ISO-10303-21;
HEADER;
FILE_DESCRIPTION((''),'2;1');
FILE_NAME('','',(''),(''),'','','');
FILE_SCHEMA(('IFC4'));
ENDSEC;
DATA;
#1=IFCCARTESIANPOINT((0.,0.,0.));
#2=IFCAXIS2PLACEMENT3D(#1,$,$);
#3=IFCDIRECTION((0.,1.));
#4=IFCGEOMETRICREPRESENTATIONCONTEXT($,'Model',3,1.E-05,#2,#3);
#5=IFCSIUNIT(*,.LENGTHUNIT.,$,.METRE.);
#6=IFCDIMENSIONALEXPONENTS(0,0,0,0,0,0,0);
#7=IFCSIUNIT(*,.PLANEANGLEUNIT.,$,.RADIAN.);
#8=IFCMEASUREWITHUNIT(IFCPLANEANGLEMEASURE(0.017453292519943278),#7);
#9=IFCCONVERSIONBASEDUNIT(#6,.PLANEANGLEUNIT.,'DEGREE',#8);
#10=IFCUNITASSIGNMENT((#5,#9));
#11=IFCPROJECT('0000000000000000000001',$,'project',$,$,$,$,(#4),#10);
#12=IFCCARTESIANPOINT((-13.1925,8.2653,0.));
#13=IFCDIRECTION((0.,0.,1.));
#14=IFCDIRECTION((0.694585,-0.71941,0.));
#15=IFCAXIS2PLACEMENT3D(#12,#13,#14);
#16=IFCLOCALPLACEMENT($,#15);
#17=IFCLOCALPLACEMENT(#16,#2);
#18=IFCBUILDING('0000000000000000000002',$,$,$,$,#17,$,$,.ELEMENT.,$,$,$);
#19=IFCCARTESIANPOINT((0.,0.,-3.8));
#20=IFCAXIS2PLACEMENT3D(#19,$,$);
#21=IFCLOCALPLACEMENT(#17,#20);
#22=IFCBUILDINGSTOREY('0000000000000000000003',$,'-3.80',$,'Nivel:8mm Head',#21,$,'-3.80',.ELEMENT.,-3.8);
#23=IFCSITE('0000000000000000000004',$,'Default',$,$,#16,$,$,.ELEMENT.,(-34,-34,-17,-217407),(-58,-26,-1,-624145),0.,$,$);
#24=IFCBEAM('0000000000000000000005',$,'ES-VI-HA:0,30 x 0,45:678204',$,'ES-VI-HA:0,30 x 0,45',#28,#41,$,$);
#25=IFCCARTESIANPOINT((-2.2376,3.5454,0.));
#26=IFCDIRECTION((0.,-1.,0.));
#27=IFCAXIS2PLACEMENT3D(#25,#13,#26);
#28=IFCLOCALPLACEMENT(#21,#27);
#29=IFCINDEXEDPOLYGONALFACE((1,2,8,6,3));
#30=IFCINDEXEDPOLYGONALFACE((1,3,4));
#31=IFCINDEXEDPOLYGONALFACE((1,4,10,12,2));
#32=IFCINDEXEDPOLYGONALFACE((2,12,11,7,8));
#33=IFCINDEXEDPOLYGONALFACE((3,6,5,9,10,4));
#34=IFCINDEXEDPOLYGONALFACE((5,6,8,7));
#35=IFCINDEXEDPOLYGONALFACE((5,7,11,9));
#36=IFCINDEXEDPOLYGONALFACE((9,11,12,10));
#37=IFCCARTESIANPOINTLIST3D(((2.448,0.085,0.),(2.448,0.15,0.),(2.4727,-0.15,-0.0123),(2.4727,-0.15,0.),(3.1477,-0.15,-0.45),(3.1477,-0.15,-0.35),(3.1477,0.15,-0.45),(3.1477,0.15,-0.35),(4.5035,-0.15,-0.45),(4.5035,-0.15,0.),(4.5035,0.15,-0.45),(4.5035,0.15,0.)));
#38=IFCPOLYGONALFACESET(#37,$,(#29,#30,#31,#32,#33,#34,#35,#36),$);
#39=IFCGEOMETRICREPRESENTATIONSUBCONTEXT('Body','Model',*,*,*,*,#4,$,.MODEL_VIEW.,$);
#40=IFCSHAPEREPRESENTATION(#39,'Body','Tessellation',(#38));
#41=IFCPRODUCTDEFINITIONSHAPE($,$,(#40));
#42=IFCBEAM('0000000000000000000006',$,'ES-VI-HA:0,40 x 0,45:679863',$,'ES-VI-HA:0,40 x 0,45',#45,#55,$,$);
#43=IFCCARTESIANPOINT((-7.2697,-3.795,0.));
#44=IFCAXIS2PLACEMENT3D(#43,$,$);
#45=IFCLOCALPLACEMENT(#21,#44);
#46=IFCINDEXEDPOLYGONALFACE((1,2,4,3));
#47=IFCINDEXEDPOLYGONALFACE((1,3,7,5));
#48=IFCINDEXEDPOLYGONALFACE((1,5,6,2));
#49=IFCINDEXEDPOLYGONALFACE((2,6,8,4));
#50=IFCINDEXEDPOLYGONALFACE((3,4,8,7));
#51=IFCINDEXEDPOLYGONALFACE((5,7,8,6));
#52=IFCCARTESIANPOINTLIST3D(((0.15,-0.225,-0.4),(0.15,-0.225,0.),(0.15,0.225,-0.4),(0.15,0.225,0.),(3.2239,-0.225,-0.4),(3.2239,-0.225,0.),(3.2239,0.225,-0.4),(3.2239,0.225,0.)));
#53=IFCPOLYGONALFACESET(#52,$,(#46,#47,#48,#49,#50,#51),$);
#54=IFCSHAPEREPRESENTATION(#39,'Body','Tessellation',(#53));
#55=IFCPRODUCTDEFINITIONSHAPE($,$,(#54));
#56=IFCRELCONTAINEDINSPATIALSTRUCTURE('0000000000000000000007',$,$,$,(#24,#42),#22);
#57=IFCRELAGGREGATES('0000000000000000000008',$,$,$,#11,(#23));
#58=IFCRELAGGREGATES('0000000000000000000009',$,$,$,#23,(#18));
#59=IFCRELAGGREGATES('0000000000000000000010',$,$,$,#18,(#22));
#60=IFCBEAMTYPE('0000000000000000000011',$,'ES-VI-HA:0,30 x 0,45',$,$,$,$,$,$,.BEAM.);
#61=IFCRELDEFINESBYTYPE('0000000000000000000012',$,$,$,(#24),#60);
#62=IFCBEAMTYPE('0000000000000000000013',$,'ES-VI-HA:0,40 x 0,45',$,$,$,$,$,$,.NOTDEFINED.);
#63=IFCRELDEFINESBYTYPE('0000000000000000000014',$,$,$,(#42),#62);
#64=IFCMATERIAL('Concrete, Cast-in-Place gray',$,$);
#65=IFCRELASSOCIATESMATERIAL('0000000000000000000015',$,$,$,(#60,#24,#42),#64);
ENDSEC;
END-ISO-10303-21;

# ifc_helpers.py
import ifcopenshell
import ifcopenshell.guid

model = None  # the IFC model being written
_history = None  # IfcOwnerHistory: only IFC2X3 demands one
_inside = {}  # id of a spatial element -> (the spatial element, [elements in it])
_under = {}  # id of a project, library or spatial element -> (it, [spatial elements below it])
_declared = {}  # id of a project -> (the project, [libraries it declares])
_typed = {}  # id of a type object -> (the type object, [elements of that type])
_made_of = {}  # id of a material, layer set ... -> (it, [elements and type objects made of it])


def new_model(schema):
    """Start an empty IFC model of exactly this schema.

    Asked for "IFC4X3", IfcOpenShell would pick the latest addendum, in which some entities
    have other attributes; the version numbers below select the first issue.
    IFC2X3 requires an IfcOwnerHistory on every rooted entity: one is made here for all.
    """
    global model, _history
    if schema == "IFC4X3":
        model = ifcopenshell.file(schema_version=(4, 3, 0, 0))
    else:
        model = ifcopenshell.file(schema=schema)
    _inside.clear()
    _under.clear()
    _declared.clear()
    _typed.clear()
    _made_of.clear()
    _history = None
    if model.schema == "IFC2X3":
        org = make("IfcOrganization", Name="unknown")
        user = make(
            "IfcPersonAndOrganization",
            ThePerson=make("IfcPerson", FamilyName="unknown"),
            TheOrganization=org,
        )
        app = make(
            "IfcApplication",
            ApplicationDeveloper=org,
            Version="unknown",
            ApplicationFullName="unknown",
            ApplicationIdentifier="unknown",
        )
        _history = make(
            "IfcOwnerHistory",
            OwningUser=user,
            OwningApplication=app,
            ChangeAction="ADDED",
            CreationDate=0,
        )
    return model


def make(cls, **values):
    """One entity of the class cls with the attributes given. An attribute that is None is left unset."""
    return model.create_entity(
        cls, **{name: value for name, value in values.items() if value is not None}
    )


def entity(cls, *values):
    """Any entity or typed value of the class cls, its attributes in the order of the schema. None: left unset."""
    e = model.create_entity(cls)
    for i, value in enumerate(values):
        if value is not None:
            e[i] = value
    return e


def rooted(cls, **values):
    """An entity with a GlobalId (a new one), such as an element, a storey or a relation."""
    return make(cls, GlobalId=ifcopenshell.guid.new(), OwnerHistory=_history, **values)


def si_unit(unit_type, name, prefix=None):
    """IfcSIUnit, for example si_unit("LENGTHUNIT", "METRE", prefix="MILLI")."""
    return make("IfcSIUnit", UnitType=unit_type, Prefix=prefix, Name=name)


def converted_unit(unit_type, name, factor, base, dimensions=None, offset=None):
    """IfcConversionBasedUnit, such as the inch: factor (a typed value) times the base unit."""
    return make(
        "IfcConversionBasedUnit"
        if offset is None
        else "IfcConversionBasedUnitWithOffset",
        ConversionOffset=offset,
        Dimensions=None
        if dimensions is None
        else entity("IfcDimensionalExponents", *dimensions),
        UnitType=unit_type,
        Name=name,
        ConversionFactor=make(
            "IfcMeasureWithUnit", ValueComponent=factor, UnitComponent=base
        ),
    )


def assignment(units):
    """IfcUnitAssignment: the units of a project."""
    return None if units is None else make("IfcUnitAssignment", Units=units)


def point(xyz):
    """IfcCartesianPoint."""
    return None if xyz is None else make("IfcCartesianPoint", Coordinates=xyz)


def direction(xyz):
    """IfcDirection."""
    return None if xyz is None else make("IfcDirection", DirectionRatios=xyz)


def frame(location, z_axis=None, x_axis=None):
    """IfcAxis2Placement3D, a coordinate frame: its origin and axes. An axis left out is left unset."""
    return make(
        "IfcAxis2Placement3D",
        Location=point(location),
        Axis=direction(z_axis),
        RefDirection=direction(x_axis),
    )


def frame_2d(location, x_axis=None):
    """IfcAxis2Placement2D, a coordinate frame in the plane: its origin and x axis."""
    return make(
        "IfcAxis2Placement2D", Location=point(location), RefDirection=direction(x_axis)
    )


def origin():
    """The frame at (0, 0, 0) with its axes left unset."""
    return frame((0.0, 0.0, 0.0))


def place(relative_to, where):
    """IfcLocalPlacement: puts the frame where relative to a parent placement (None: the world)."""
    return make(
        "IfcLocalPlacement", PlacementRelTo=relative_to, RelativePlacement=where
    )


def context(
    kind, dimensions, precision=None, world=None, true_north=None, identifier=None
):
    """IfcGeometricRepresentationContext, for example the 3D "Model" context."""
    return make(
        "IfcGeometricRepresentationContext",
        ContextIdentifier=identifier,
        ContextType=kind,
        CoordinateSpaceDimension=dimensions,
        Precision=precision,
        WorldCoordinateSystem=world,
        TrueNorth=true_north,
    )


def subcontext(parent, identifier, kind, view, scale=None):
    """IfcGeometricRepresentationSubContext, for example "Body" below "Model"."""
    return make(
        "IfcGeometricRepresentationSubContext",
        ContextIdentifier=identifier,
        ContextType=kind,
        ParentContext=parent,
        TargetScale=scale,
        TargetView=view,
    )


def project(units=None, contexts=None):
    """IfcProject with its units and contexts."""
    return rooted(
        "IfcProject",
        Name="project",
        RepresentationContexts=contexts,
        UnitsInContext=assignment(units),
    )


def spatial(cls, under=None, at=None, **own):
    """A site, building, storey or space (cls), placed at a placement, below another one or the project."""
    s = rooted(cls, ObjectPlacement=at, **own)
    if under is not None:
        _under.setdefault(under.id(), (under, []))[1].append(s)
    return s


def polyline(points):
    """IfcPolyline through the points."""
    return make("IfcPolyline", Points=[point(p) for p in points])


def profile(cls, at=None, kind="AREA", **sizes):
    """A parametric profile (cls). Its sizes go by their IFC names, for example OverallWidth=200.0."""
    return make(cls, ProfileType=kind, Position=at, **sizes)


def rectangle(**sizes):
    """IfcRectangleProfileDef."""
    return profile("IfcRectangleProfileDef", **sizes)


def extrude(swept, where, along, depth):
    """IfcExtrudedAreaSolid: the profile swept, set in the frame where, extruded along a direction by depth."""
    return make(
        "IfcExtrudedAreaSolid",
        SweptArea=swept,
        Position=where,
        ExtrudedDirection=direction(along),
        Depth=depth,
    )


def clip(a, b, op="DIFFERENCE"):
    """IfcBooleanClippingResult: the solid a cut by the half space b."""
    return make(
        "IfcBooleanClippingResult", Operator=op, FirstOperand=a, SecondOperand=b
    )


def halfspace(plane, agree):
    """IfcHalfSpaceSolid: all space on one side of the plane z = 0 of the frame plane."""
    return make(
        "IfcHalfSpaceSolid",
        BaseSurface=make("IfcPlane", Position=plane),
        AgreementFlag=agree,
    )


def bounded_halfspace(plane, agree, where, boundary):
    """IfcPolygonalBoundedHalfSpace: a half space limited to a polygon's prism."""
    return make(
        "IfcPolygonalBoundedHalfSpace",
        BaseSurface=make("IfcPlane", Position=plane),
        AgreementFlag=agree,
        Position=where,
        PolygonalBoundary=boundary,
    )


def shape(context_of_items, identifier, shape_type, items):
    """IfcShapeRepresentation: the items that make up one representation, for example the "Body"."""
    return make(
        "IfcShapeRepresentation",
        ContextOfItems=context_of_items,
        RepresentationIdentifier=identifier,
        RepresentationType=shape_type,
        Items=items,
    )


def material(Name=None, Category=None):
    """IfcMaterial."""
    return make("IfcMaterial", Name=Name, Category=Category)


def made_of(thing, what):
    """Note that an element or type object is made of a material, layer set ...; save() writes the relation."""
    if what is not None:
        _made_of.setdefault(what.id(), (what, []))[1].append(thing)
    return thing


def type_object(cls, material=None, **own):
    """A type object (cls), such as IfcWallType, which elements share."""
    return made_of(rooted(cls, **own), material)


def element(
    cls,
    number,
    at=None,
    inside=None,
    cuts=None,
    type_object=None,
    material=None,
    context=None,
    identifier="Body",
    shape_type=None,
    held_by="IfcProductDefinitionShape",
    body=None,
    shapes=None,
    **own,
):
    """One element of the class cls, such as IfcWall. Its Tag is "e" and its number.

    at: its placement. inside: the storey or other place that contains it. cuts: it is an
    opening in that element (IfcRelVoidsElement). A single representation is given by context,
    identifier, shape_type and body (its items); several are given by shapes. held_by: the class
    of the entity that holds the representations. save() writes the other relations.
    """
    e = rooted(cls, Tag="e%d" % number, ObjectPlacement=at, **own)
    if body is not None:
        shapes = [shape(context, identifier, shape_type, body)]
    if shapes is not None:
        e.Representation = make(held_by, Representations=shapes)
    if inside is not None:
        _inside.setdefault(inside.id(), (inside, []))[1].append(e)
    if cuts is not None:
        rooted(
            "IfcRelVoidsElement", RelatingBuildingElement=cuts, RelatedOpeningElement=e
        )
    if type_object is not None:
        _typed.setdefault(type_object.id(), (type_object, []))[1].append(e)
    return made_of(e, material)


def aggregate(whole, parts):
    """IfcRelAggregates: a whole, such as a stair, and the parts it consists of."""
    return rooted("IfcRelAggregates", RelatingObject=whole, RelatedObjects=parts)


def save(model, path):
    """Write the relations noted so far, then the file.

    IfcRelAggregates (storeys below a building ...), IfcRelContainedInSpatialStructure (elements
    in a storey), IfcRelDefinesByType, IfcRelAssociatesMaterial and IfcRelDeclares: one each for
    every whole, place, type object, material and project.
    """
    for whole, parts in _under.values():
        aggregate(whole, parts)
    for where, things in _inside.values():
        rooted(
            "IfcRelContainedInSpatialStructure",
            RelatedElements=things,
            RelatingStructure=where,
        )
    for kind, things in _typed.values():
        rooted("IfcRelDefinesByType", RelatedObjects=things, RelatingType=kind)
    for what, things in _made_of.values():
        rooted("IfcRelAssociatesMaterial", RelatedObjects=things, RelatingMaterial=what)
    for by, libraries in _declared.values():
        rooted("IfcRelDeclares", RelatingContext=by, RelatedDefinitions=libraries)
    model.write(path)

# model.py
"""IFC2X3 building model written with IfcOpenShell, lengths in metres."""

from ifc_helpers import new_model, entity, si_unit, converted_unit, direction, frame, frame_2d, origin, place, context, subcontext, project, spatial, polyline, rectangle, extrude, clip, halfspace, bounded_halfspace, material, type_object, element, save


model = new_model("IFC2X3")

# Units and contexts
model_context = context("Model", 3, precision=1e-05, world=origin(), true_north=direction((0.0, 1.0)))
body_context = subcontext(model_context, "Body", "Model", "MODEL_VIEW")
ifc_project = project(units=[si_unit("LENGTHUNIT", "METRE"), converted_unit("PLANEANGLEUNIT", "DEGREE", entity("IfcPlaneAngleMeasure", 0.017453292519943278), si_unit("PLANEANGLEUNIT", "RADIAN"), dimensions=[0, 0, 0, 0, 0, 0, 0])], contexts=[model_context])

# Site, building, storey
site_placement = place(None, frame((-13.1925, 8.2653, 0.0), z_axis=(0.0, 0.0, 1.0), x_axis=(0.694585, -0.71941, 0.0)))
site = spatial("IfcSite", under=ifc_project, at=site_placement, Name="Default", CompositionType="ELEMENT", RefLatitude=(-34, -34, -17, -217407), RefLongitude=(-58, -26, -1, -624145), RefElevation=0.0)
building_placement = place(site_placement, origin())
building = spatial("IfcBuilding", under=site, at=building_placement, CompositionType="ELEMENT")
storey_placement = place(building_placement, frame((0.0, 0.0, -3.8)))
storey = spatial("IfcBuildingStorey", under=building, at=storey_placement, Name="-3.80", ObjectType="Nivel:8mm Head", LongName="-3.80", CompositionType="ELEMENT", Elevation=-3.8)

# Beams
ifc_material_1 = material(Name="Concrete, Cast-in-Place gray")
beam_type_1 = type_object("IfcBeamType", Name="ES-VI-HA:0,30 x 0,45", PredefinedType="BEAM", material=ifc_material_1)
beam_1_placement = place(storey_placement, frame((-2.2376, 3.5454, 0.0), z_axis=(0.0, 0.0, 1.0), x_axis=(0.0, -1.0, 0.0)))
element("IfcBeam", 1, at=beam_1_placement, inside=storey, type_object=beam_type_1, material=ifc_material_1, Name="ES-VI-HA:0,30 x 0,45:678204", ObjectType="ES-VI-HA:0,30 x 0,45", context=body_context, shape_type="SweptSolid", body=[
    clip(clip(clip(extrude(rectangle(XDim=0.45, YDim=0.3, at=frame_2d((0.0, 0.0), x_axis=(0.0, 1.0))), frame((2.448, 0.0, -0.225), z_axis=(1.0, 0.0, 0.0), x_axis=(0.0, 1.0, 0.0)), (0.0, 0.0, 1.0), 2.0555), halfspace(frame((2.4569, 0.0, -0.4), z_axis=(-0.994528, -0.104473, 0.0), x_axis=(0.0, 0.0, 1.0)), False)), bounded_halfspace(frame((3.1477, -0.0015, -0.35), z_axis=(-0.447361, 0.0, -0.894354), x_axis=(0.0, 1.0, 0.0)), False, frame((2.448, 0.0, -0.225), z_axis=(1.0, 0.0, 0.0), x_axis=(0.0, 1.0, 0.0)), polyline([(0.15, -0.125), (-0.15, -0.125), (-0.15, 0.2127), (0.085, 0.225), (0.15, 0.225), (0.15, -0.125)]))), bounded_halfspace(frame((3.1477, -1.0515, -0.35), z_axis=(-1.0, 0.0, 0.0), x_axis=(0.0, 0.0, -1.0)), False, frame((2.448, 0.0, -0.225), z_axis=(1.0, 0.0, 0.0), x_axis=(0.0, 1.0, 0.0)), polyline([(-0.15, -0.125), (0.15, -0.125), (0.15, -0.225), (-0.15, -0.225), (-0.15, -0.125)]))),
])
beam_type_2 = type_object("IfcBeamType", Name="ES-VI-HA:0,40 x 0,45", PredefinedType="NOTDEFINED")
beam_2_placement = place(storey_placement, frame((-7.2697, -3.795, 0.0)))
element("IfcBeam", 2, at=beam_2_placement, inside=storey, type_object=beam_type_2, material=ifc_material_1, Name="ES-VI-HA:0,40 x 0,45:679863", ObjectType="ES-VI-HA:0,40 x 0,45", context=body_context, shape_type="SweptSolid", body=[
    extrude(rectangle(XDim=0.4, YDim=0.45, at=frame_2d((0.0, 0.0), x_axis=(1.0, 0.0))), frame((0.15, 0.0, -0.2), z_axis=(1.0, 0.0, 0.0), x_axis=(0.0, 0.0, -1.0)), (0.0, 0.0, 1.0), 3.0739),
])

save(model, "model.ifc")
